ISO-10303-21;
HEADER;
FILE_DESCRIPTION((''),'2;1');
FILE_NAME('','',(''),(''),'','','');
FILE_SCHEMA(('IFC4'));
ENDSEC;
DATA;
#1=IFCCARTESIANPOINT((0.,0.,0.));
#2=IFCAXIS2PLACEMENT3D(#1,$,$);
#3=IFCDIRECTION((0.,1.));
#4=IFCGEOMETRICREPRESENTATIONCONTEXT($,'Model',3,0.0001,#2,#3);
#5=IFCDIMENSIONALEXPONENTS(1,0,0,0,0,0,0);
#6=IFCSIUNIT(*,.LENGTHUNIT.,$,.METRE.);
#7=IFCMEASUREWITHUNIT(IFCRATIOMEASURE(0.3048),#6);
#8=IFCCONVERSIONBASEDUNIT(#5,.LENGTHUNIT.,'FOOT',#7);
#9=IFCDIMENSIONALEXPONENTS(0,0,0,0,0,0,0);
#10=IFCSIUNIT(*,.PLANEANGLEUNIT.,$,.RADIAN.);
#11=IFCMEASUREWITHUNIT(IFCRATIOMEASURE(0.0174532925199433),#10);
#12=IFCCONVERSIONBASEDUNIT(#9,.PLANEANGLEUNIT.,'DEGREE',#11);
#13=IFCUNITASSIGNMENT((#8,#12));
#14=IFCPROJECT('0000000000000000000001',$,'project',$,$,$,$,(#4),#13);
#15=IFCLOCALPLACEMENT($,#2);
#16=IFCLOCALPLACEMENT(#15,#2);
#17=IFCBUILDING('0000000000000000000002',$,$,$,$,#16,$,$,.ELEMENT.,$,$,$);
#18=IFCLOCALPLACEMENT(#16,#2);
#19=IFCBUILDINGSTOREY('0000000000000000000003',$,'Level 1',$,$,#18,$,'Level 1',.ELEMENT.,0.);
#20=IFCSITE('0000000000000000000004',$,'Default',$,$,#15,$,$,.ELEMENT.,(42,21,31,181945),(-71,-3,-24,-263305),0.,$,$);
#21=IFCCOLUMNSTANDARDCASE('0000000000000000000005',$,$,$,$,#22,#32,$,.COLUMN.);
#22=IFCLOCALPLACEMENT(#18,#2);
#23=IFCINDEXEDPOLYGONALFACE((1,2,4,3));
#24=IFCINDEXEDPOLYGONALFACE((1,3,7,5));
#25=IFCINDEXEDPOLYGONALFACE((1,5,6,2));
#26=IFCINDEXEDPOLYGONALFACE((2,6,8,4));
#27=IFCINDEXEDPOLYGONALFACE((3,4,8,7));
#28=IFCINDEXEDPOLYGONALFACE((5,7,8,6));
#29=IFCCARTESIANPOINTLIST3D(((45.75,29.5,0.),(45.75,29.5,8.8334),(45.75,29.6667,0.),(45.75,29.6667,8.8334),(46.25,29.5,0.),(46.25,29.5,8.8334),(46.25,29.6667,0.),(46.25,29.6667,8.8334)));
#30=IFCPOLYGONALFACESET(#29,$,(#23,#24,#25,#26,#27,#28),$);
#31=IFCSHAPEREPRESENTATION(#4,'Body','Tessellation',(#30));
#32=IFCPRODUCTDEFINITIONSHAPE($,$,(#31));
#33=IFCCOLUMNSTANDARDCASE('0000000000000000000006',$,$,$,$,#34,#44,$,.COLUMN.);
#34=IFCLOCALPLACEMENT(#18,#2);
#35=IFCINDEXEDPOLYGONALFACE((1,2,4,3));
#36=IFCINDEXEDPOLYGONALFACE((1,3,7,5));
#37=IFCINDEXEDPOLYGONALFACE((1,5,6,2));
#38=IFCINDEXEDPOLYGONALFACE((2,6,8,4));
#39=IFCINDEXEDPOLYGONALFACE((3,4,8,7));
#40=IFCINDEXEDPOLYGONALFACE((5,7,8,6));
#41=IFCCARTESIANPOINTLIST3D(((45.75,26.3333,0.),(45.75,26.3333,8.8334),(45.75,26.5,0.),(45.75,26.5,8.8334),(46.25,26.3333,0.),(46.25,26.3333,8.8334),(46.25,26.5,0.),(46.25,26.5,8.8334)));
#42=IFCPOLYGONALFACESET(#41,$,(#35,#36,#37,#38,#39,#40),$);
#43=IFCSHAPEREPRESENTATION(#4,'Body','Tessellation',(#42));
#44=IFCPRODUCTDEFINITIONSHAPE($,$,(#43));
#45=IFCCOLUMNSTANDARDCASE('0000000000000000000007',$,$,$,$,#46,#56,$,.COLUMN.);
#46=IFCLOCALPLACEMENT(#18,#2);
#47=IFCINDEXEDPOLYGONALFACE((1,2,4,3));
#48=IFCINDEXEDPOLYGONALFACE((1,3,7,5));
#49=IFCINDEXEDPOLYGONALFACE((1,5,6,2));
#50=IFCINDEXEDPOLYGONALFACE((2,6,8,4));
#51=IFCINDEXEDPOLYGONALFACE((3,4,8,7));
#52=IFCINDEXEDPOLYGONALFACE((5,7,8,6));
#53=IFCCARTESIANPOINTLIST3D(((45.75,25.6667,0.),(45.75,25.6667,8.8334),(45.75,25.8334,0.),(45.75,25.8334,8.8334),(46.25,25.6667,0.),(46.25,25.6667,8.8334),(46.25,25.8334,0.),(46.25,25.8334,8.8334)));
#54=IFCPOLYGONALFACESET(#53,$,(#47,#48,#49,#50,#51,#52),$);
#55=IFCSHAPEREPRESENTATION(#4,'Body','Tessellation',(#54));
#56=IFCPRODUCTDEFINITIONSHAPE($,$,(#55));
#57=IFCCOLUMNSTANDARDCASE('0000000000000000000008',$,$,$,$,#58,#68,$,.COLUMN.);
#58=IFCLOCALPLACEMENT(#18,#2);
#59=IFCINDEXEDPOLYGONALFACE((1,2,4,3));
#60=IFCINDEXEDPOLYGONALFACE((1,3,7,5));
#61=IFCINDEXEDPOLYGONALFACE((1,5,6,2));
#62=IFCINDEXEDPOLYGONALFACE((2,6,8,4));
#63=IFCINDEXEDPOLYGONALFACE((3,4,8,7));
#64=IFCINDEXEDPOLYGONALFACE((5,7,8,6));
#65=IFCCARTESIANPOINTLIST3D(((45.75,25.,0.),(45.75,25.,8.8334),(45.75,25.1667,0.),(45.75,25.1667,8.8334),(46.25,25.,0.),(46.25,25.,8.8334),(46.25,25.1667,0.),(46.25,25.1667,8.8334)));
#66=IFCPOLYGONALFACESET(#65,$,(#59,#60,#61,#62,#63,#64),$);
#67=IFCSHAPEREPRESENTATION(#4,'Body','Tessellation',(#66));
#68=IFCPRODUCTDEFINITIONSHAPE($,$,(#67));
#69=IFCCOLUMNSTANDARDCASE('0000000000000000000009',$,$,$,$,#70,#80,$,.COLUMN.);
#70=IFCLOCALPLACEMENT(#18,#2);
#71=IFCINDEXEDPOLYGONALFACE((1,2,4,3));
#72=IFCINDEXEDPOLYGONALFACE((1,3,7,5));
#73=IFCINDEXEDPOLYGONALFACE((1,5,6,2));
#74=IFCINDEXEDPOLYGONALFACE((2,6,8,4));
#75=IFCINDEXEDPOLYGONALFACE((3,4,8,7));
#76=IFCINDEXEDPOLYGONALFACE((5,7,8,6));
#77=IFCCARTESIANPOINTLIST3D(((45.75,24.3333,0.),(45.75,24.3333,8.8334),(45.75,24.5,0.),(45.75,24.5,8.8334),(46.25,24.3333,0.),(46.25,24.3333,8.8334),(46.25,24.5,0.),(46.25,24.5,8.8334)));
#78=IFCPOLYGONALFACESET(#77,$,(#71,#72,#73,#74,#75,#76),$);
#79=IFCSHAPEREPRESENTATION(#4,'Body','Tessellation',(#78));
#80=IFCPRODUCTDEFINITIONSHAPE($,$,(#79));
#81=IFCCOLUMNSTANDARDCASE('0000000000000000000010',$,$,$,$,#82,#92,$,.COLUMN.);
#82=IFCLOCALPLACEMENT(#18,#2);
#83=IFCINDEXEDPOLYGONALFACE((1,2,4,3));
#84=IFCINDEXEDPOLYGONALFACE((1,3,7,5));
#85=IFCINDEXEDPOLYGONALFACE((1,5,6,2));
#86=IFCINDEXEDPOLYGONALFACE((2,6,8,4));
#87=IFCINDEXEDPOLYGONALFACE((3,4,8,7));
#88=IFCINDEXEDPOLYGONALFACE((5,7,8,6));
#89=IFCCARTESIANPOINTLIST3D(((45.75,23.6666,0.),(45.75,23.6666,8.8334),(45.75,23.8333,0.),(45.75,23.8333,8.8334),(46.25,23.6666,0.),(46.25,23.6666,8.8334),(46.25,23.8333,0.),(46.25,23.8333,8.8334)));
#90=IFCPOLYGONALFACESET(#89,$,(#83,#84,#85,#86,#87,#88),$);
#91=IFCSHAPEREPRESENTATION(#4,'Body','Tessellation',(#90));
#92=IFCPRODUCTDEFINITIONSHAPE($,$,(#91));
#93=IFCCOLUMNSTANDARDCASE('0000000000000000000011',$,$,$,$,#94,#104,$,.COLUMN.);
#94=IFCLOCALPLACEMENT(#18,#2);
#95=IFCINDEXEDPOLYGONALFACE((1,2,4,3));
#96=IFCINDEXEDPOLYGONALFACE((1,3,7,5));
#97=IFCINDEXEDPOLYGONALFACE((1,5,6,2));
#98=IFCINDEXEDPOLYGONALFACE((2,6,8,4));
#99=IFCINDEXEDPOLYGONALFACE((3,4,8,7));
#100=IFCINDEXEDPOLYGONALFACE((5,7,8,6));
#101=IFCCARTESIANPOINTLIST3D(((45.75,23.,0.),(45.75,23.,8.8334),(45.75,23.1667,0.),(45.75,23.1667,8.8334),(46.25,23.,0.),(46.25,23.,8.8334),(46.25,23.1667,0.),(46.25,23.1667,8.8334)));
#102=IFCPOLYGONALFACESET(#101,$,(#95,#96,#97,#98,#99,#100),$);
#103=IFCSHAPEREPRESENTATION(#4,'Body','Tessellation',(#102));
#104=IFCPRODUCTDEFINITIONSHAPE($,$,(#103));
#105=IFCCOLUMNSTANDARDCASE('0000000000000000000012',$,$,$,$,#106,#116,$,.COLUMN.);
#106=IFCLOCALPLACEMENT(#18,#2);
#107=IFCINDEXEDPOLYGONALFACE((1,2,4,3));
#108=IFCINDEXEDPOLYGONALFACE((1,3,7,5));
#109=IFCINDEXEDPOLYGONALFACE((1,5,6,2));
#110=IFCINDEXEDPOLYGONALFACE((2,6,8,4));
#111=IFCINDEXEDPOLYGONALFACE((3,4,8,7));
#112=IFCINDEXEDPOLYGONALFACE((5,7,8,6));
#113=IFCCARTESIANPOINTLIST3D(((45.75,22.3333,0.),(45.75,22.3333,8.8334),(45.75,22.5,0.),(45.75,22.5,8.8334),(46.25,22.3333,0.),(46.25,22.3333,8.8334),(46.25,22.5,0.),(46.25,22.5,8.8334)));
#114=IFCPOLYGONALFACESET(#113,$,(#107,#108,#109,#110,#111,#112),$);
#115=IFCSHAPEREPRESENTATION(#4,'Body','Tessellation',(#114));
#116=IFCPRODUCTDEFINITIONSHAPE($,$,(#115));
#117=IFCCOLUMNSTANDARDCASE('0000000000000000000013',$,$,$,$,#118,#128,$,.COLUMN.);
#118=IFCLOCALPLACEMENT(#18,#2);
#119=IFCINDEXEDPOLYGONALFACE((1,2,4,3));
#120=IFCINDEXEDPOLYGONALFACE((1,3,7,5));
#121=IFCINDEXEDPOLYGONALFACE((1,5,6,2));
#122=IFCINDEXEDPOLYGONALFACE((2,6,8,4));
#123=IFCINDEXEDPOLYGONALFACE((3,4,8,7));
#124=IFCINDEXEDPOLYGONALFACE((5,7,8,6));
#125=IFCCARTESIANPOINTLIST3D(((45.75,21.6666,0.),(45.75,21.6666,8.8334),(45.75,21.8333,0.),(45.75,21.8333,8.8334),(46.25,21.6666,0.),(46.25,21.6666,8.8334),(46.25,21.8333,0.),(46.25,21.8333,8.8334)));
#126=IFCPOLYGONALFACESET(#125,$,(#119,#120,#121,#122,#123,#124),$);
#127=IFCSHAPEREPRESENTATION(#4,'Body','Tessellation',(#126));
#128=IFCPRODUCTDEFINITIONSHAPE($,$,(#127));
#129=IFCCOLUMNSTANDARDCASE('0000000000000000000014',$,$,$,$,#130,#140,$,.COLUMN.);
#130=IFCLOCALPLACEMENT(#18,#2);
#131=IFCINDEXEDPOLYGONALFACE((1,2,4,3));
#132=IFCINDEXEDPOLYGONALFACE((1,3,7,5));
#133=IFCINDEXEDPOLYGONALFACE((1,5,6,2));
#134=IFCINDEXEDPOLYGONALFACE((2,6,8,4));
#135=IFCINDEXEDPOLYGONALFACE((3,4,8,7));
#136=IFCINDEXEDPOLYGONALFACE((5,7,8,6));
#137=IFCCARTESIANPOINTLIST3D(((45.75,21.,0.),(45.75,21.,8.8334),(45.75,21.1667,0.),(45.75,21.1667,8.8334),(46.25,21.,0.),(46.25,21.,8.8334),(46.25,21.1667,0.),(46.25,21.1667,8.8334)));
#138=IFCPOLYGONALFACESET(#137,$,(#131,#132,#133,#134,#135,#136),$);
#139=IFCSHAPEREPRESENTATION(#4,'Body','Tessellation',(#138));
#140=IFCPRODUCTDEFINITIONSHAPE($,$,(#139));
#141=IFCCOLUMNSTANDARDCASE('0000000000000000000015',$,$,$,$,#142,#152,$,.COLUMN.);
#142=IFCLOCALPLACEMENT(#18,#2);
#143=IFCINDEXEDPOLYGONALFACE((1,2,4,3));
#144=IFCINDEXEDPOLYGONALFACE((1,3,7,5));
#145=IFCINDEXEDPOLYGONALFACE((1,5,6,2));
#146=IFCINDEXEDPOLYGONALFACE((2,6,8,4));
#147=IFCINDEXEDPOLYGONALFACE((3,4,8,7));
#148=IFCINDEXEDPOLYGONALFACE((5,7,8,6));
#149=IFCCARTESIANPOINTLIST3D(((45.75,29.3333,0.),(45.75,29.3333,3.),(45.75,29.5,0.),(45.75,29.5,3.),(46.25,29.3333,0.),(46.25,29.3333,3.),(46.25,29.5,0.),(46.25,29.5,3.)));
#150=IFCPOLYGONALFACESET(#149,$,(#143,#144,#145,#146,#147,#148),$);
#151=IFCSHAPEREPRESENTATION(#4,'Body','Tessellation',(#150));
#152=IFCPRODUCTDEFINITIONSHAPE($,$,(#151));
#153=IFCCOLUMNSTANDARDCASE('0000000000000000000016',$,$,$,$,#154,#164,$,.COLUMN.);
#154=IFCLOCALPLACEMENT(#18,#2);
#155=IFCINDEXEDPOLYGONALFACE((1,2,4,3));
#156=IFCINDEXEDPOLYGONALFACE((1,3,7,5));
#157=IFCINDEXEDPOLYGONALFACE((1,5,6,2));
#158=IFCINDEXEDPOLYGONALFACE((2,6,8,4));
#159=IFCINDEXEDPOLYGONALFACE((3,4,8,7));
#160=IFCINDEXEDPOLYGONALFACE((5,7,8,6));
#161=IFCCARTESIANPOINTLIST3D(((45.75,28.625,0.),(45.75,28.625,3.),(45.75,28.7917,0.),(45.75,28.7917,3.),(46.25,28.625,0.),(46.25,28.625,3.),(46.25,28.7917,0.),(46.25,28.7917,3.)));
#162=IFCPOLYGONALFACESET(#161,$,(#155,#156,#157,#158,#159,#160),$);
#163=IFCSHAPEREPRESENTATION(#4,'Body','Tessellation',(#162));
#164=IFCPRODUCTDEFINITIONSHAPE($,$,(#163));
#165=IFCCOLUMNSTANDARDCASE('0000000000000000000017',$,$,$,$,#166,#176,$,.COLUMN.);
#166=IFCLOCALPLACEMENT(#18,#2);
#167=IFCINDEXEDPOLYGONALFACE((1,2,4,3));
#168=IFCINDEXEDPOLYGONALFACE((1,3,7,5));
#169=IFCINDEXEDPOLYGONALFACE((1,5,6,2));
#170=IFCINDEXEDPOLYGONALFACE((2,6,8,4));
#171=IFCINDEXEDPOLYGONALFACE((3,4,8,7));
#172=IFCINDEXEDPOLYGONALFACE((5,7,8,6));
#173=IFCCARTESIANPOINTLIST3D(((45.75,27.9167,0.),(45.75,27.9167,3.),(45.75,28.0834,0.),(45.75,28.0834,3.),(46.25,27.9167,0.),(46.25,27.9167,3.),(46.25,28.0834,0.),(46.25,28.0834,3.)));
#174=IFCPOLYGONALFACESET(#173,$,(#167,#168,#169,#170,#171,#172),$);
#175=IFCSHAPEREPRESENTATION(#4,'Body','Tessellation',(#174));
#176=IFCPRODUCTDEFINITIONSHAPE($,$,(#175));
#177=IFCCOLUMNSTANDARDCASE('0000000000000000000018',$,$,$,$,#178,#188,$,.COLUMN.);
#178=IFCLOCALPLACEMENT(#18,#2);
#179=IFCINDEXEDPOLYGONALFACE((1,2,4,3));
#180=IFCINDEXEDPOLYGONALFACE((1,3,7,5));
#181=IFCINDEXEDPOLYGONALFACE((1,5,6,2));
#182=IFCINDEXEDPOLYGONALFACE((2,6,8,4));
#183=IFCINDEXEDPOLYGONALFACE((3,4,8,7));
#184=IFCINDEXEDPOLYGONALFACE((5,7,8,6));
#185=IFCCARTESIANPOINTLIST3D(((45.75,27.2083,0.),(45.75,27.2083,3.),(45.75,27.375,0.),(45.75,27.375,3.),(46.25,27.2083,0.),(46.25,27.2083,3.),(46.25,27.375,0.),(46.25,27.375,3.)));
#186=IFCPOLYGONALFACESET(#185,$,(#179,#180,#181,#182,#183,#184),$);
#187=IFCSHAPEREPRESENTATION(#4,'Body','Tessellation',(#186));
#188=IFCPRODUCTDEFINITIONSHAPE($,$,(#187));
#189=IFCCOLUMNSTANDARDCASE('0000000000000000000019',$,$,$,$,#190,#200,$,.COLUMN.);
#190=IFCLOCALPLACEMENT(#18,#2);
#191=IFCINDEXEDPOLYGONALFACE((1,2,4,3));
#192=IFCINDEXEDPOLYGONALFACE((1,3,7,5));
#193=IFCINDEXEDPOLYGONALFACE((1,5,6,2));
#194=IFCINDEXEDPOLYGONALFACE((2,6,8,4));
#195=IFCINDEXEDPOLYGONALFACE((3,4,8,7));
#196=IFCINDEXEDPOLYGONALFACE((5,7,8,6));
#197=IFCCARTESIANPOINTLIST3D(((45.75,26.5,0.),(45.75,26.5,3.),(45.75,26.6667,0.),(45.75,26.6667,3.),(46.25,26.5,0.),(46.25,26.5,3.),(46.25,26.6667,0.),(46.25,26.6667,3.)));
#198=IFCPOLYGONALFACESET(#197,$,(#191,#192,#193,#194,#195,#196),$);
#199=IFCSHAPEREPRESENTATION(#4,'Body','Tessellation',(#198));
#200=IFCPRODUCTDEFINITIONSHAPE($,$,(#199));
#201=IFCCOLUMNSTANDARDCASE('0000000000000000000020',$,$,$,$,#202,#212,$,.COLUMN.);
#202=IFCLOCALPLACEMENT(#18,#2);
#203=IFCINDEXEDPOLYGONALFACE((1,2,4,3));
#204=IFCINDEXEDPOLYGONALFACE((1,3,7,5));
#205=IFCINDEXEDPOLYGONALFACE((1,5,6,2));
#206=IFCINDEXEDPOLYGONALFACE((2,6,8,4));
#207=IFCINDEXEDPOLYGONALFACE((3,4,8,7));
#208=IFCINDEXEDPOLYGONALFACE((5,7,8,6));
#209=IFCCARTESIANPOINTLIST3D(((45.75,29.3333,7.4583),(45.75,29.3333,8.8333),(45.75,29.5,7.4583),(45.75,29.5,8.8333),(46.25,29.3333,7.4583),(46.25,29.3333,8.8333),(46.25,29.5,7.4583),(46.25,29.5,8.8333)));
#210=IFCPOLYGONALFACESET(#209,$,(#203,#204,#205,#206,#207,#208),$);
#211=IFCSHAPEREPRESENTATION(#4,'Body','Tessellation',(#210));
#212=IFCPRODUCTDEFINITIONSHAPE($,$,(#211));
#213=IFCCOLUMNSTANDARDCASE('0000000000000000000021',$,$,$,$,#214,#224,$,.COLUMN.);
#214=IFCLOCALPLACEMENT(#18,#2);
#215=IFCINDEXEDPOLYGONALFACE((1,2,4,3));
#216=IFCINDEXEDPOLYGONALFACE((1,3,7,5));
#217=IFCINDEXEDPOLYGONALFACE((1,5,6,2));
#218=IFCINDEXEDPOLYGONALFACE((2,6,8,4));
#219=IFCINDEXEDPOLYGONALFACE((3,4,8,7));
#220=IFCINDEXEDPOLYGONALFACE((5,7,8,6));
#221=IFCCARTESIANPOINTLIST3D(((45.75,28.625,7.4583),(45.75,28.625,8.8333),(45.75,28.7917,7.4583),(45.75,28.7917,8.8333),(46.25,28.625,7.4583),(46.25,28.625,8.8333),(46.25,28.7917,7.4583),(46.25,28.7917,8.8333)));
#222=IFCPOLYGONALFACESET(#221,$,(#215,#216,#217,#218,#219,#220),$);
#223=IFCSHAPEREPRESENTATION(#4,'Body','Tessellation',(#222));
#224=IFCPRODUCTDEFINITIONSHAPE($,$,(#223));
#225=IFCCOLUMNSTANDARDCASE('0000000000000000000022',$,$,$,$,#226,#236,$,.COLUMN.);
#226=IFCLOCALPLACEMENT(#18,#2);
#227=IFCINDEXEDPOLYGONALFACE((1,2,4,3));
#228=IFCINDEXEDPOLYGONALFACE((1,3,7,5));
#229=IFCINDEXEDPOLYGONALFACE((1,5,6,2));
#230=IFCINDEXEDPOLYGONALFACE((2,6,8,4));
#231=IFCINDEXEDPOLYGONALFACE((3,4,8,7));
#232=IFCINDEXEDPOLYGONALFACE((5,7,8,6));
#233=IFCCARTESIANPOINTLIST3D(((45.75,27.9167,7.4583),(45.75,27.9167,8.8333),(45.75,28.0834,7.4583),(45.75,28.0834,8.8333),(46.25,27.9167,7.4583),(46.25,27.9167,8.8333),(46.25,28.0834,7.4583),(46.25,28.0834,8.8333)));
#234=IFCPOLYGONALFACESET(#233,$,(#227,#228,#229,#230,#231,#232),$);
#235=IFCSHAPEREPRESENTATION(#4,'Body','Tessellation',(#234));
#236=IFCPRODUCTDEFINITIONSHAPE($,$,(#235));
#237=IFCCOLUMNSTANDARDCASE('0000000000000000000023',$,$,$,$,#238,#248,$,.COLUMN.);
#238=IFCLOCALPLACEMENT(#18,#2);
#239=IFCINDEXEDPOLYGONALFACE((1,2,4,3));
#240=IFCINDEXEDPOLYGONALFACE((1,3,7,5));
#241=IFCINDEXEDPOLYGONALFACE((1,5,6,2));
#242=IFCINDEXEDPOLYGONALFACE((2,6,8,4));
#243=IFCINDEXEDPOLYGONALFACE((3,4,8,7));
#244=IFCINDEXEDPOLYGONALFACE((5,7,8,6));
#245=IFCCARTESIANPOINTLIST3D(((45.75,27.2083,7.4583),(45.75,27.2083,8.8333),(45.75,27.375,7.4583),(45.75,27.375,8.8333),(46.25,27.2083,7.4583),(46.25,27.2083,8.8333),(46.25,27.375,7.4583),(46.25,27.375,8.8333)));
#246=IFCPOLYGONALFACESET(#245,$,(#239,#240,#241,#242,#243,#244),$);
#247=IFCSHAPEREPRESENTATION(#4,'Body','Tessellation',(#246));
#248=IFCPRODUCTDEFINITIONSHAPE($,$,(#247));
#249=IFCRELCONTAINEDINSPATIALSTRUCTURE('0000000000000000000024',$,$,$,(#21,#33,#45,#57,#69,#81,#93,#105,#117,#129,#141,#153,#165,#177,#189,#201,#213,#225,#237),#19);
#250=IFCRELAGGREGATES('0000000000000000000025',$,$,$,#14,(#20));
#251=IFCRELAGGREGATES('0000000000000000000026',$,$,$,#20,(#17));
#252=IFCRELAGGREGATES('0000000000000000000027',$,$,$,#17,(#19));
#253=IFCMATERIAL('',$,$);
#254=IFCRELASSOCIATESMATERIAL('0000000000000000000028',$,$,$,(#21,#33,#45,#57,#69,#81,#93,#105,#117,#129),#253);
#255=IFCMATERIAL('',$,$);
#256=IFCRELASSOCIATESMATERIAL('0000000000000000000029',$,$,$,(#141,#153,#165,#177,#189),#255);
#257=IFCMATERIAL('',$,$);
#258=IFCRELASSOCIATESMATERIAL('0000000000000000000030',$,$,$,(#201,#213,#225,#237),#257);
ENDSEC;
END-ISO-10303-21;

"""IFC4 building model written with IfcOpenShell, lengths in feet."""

from ifc_helpers import new_model, entity, si_unit, converted_unit, direction, frame, origin, place, context, project, spatial, rectangle, extrude, material, element, save


model = new_model("IFC4")

# Units and contexts
model_context = context("Model", 3, precision=0.0001, world=origin(), true_north=direction((0.0, 1.0)))
ifc_project = project(units=[converted_unit("LENGTHUNIT", "FOOT", entity("IfcRatioMeasure", 0.3048), si_unit("LENGTHUNIT", "METRE"), dimensions=[1, 0, 0, 0, 0, 0, 0]), converted_unit("PLANEANGLEUNIT", "DEGREE", entity("IfcRatioMeasure", 0.0174532925199433), si_unit("PLANEANGLEUNIT", "RADIAN"), dimensions=[0, 0, 0, 0, 0, 0, 0])], contexts=[model_context])

# Site, building, storey
site_placement = place(None, origin())
site = spatial("IfcSite", under=ifc_project, at=site_placement, Name="Default", CompositionType="ELEMENT", RefLatitude=(42, 21, 31, 181945), RefLongitude=(-71, -3, -24, -263305), RefElevation=0.0)
building_placement = place(site_placement, origin())
building = spatial("IfcBuilding", under=site, at=building_placement, CompositionType="ELEMENT")
storey_placement = place(building_placement, origin())
storey = spatial("IfcBuildingStorey", under=building, at=storey_placement, Name="Level 1", LongName="Level 1", CompositionType="ELEMENT", Elevation=0.0)

# Columns
ifc_material_1 = material(Name="")
placement_1 = place(storey_placement, frame((46.0, 46.25, 0.0), z_axis=(0.0, 0.0, 1.0), x_axis=(0.0, -1.0, 0.0)))
for number, where, z_axis, x_axis in (
    (1, (16.6667, 0.0, 0.0), (0.0, 0.0, 1.0), (1.0, 0.0, 0.0)),
    (2, (19.8334, 0.0, 0.0), (0.0, 0.0, 1.0), (1.0, 0.0, 0.0)),
    (3, (20.5, 0.0, 0.0), (0.0, 0.0, 1.0), (1.0, 0.0, 0.0)),
    (4, (21.1667, 0.0, 0.0), (0.0, 0.0, 1.0), (1.0, 0.0, 0.0)),
    (5, (21.8334, 0.0, 0.0), (0.0, 0.0, 1.0), (1.0, 0.0, 0.0)),
    (6, (22.5001, 0.0, 0.0), (0.0, 0.0, 1.0), (1.0, 0.0, 0.0)),
    (7, (23.1667, 0.0, 0.0), (0.0, 0.0, 1.0), (1.0, 0.0, 0.0)),
    (8, (23.8334, 0.0, 0.0), (0.0, 0.0, 1.0), (1.0, 0.0, 0.0)),
    (9, (24.5001, 0.0, 0.0), (0.0, 0.0, 1.0), (1.0, 0.0, 0.0)),
    (10, (25.1667, 0.0, 0.0), (0.0, 0.0, 1.0), (1.0, 0.0, 0.0)),
):
    element("IfcColumnStandardCase", number, at=place(placement_1, frame(where, z_axis=z_axis, x_axis=x_axis)), inside=storey, material=ifc_material_1, PredefinedType="COLUMN", context=model_context, shape_type="SweptSolid", body=[
        extrude(rectangle(XDim=0.1667, YDim=0.5), origin(), (0.0, 0.0, 1.0), 8.8334),
    ])
ifc_material_2 = material(Name="")
for number, where, z_axis, x_axis in (
    (11, (16.8334, 0.0, 0.0), (0.0, 0.0, 1.0), (1.0, 0.0, 0.0)),
    (12, (17.5417, 0.0, 0.0), (0.0, 0.0, 1.0), (1.0, 0.0, 0.0)),
    (13, (18.25, 0.0, 0.0), (0.0, 0.0, 1.0), (1.0, 0.0, 0.0)),
    (14, (18.9584, 0.0, 0.0), (0.0, 0.0, 1.0), (1.0, 0.0, 0.0)),
    (15, (19.6667, 0.0, 0.0), (0.0, 0.0, 1.0), (1.0, 0.0, 0.0)),
):
    element("IfcColumnStandardCase", number, at=place(placement_1, frame(where, z_axis=z_axis, x_axis=x_axis)), inside=storey, material=ifc_material_2, PredefinedType="COLUMN", context=model_context, shape_type="SweptSolid", body=[
        extrude(rectangle(XDim=0.1667, YDim=0.5), origin(), (0.0, 0.0, 1.0), 3.0),
    ])
ifc_material_3 = material(Name="")
for number, where, z_axis, x_axis in (
    (16, (16.8334, 0.0, 7.4583), (0.0, 0.0, 1.0), (1.0, 0.0, 0.0)),
    (17, (17.5417, 0.0, 7.4583), (0.0, 0.0, 1.0), (1.0, 0.0, 0.0)),
    (18, (18.25, 0.0, 7.4583), (0.0, 0.0, 1.0), (1.0, 0.0, 0.0)),
    (19, (18.9584, 0.0, 7.4583), (0.0, 0.0, 1.0), (1.0, 0.0, 0.0)),
):
    element("IfcColumnStandardCase", number, at=place(placement_1, frame(where, z_axis=z_axis, x_axis=x_axis)), inside=storey, material=ifc_material_3, PredefinedType="COLUMN", context=model_context, shape_type="SweptSolid", body=[
        extrude(rectangle(XDim=0.1667, YDim=0.5), origin(), (0.0, 0.0, 1.0), 1.375),
    ])

save(model, "model.ifc")
